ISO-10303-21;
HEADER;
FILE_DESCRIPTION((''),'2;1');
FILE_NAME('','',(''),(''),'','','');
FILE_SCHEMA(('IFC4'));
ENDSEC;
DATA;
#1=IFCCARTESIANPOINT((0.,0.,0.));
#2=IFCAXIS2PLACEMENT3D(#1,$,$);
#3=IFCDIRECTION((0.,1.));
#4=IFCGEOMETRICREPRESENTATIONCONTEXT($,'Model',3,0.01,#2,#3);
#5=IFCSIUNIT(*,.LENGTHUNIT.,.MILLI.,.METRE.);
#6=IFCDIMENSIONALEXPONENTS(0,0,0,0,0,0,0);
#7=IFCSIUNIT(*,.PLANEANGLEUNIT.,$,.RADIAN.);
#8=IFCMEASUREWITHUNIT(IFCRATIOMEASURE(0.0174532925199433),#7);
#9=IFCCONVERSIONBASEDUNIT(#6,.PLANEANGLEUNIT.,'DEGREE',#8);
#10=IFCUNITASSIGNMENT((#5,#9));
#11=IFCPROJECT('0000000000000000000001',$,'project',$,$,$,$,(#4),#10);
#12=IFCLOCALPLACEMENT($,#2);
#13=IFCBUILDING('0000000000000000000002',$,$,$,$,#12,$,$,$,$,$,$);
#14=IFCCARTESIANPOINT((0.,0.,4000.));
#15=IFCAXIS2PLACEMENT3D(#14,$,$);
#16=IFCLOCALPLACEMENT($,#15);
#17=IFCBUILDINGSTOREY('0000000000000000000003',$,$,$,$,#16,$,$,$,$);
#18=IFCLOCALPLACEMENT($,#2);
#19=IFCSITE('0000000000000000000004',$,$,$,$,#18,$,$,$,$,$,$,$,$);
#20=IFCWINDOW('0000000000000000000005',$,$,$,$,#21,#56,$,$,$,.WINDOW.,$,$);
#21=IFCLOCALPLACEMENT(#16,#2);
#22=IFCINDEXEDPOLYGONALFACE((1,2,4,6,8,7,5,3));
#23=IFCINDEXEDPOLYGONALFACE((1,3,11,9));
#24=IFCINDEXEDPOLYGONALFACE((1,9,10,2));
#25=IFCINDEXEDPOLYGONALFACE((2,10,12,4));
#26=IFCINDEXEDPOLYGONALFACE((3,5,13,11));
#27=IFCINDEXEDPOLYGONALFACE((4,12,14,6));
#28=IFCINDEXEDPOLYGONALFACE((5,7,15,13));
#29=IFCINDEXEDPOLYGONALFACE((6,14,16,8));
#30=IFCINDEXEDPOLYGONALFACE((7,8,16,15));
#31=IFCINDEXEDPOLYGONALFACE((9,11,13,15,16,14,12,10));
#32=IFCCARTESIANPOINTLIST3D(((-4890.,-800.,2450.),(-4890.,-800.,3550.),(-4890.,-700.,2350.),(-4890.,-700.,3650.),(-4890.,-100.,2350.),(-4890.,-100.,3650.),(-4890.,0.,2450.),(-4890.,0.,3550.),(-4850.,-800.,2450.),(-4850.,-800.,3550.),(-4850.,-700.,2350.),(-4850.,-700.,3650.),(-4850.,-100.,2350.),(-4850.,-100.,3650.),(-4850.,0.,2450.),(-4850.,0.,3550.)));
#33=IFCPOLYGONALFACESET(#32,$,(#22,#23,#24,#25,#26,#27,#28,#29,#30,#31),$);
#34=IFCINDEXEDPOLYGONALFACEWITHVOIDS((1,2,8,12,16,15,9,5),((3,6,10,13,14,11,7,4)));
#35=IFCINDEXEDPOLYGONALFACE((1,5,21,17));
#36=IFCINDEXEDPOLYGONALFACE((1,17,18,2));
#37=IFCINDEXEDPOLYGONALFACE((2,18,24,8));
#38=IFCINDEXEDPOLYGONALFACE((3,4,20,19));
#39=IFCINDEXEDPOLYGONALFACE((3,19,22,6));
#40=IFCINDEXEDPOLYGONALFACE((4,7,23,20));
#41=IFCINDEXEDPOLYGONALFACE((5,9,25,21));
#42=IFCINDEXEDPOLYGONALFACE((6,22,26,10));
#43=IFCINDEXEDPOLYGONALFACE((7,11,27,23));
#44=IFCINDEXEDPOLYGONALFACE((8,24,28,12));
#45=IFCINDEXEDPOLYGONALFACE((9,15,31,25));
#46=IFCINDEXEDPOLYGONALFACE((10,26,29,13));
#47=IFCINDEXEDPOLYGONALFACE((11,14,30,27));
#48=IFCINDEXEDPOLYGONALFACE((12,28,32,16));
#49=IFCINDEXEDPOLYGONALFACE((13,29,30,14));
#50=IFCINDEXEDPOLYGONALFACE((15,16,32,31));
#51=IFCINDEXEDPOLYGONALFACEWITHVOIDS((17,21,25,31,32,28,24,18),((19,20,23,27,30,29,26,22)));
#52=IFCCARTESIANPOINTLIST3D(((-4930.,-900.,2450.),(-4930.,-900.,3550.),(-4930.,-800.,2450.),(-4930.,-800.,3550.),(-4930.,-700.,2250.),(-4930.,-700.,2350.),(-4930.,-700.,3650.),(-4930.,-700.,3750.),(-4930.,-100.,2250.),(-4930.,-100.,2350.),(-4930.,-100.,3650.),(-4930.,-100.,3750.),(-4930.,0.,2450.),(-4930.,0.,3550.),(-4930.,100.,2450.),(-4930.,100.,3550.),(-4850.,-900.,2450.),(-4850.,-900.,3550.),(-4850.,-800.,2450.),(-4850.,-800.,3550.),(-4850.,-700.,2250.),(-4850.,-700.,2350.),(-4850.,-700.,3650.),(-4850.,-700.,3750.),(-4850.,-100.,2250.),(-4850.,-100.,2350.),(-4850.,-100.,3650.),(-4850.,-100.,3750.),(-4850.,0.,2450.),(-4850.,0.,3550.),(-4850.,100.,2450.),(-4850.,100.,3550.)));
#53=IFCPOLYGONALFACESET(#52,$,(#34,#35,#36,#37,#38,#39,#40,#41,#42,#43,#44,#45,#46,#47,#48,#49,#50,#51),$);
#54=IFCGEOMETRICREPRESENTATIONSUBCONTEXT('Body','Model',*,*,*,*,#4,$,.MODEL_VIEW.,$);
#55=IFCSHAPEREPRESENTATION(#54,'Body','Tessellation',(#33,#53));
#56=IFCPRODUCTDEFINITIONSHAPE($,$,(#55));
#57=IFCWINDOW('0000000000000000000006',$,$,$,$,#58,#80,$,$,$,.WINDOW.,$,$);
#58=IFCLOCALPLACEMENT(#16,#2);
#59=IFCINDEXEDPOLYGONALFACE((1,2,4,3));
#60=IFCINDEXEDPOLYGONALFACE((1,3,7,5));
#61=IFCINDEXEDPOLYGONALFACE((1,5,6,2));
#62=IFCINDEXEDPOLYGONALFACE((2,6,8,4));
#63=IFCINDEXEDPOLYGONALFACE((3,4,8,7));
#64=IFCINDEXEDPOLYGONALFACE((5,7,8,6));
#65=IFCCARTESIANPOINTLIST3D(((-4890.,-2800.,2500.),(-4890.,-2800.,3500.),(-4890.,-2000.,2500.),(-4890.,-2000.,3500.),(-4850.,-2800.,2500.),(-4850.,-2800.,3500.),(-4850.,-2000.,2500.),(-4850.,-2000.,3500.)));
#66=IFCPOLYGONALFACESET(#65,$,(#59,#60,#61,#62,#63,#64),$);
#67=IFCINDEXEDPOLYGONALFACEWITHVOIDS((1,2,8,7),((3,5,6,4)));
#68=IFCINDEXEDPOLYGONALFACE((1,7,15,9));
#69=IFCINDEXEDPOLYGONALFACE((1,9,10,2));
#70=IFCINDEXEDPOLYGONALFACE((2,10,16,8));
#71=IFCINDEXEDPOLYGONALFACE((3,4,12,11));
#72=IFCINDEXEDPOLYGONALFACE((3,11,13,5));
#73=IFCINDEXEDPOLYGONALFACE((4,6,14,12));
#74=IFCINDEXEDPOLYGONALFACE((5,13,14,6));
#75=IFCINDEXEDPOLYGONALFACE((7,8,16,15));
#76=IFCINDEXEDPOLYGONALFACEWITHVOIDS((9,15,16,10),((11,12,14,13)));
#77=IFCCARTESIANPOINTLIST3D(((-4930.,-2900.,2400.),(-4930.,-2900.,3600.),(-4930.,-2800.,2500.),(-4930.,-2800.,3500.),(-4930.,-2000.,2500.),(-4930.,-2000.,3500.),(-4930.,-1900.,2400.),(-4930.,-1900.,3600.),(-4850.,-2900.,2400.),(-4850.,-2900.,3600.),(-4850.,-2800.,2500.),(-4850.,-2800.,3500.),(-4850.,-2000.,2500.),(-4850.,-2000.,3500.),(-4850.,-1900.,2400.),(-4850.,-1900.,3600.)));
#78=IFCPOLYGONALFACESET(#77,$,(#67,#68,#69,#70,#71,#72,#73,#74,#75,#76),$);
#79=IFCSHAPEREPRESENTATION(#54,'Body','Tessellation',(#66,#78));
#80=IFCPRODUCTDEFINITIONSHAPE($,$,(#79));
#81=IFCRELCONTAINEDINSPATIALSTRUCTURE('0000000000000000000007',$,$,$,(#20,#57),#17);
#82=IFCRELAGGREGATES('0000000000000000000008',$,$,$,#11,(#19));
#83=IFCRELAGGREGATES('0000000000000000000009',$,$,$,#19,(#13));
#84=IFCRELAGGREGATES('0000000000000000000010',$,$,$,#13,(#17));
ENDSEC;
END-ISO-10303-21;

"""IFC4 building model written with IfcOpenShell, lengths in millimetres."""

from ifc_helpers import new_model, entity, si_unit, converted_unit, direction, frame, origin, place, context, subcontext, project, spatial, element, save


model = new_model("IFC4")

# Units and contexts
model_context = context("Model", 3, precision=0.01, world=origin(), true_north=direction((0.0, 1.0)))
body_context = subcontext(model_context, "Body", "Model", "MODEL_VIEW")
ifc_project = project(units=[si_unit("LENGTHUNIT", "METRE", prefix="MILLI"), converted_unit("PLANEANGLEUNIT", "DEGREE", entity("IfcRatioMeasure", 0.0174532925199433), si_unit("PLANEANGLEUNIT", "RADIAN"), dimensions=[0, 0, 0, 0, 0, 0, 0])], contexts=[model_context])

# Site, building, storey
site_placement = place(None, origin())
site = spatial("IfcSite", under=ifc_project, at=site_placement)
building_placement = place(None, origin())
building = spatial("IfcBuilding", under=site, at=building_placement)
storey_placement = place(None, frame((0.0, 0.0, 4000.0)))
storey = spatial("IfcBuildingStorey", under=building, at=storey_placement)

# Shared definitions
cartesian_point_1 = entity("IfcCartesianPoint", [-400.0, -550.0])
shared_polyline_1 = entity("IfcPolyline", [cartesian_point_1, entity("IfcCartesianPoint", [-400.0, 550.0]), entity("IfcCartesianPoint", [-300.0, 650.0]), entity("IfcCartesianPoint", [300.0, 650.0]), entity("IfcCartesianPoint", [400.0, 550.0]), entity("IfcCartesianPoint", [400.0, -550.0]), entity("IfcCartesianPoint", [300.0, -650.0]), entity("IfcCartesianPoint", [-300.0, -650.0]), cartesian_point_1])
cartesian_point_2 = entity("IfcCartesianPoint", [-400.0, -500.0])
shared_polyline_2 = entity("IfcPolyline", [cartesian_point_2, entity("IfcCartesianPoint", [-400.0, 500.0]), entity("IfcCartesianPoint", [-400.0, 500.0]), entity("IfcCartesianPoint", [400.0, 500.0]), entity("IfcCartesianPoint", [400.0, 500.0]), entity("IfcCartesianPoint", [400.0, -500.0]), entity("IfcCartesianPoint", [400.0, -500.0]), entity("IfcCartesianPoint", [-400.0, -500.0]), cartesian_point_2])

# Shared definitions
wall_1_placement = place(storey_placement, frame((-4900.0, 100.0, 0.0), z_axis=(0.0, 0.0, 1.0), x_axis=(0.0, -1.0, 0.0)))
window_1_placement = place(wall_1_placement, frame((500.0, 50.0, 3000.0)))
window_2_placement = place(wall_1_placement, frame((2500.0, 50.0, 3000.0)))

# Windows
cartesian_point_3 = entity("IfcCartesianPoint", [-500.0, -550.0])
element("IfcWindow", 1, at=window_1_placement, inside=storey, PredefinedType="WINDOW", context=body_context, shape_type="SweptSolid", body=[
    entity("IfcExtrudedAreaSolid", entity("IfcArbitraryClosedProfileDef", "AREA", None, shared_polyline_1), entity("IfcAxis2Placement3D", entity("IfcCartesianPoint", [0.0, 0.0, 0.0]), entity("IfcDirection", [0.0, -1.0, 0.0]), entity("IfcDirection", [1.0, 0.0, 0.0])), entity("IfcDirection", [0.0, 0.0, 1.0]), 40.0),
    entity("IfcExtrudedAreaSolid", entity("IfcArbitraryProfileDefWithVoids", "AREA", None, entity("IfcPolyline", [cartesian_point_3, entity("IfcCartesianPoint", [-500.0, 550.0]), entity("IfcCartesianPoint", [-300.0, 750.0]), entity("IfcCartesianPoint", [300.0, 750.0]), entity("IfcCartesianPoint", [500.0, 550.0]), entity("IfcCartesianPoint", [500.0, -550.0]), entity("IfcCartesianPoint", [300.0, -750.0]), entity("IfcCartesianPoint", [-300.0, -750.0]), cartesian_point_3]), [shared_polyline_1]), entity("IfcAxis2Placement3D", entity("IfcCartesianPoint", [0.0, 0.0, 0.0]), entity("IfcDirection", [0.0, -1.0, 0.0]), entity("IfcDirection", [1.0, 0.0, 0.0])), entity("IfcDirection", [0.0, 0.0, 1.0]), 80.0),
])
cartesian_point_4 = entity("IfcCartesianPoint", [-500.0, -600.0])
element("IfcWindow", 2, at=window_2_placement, inside=storey, PredefinedType="WINDOW", context=body_context, shape_type="SweptSolid", body=[
    entity("IfcExtrudedAreaSolid", entity("IfcArbitraryClosedProfileDef", "AREA", None, shared_polyline_2), entity("IfcAxis2Placement3D", entity("IfcCartesianPoint", [0.0, 0.0, 0.0]), entity("IfcDirection", [0.0, -1.0, 0.0]), entity("IfcDirection", [1.0, 0.0, 0.0])), entity("IfcDirection", [0.0, 0.0, 1.0]), 40.0),
    entity("IfcExtrudedAreaSolid", entity("IfcArbitraryProfileDefWithVoids", "AREA", None, entity("IfcPolyline", [cartesian_point_4, entity("IfcCartesianPoint", [-500.0, 600.0]), entity("IfcCartesianPoint", [-500.0, 600.0]), entity("IfcCartesianPoint", [500.0, 600.0]), entity("IfcCartesianPoint", [500.0, 600.0]), entity("IfcCartesianPoint", [500.0, -600.0]), entity("IfcCartesianPoint", [500.0, -600.0]), entity("IfcCartesianPoint", [-500.0, -600.0]), cartesian_point_4]), [shared_polyline_2]), entity("IfcAxis2Placement3D", entity("IfcCartesianPoint", [0.0, 0.0, 0.0]), entity("IfcDirection", [0.0, -1.0, 0.0]), entity("IfcDirection", [1.0, 0.0, 0.0])), entity("IfcDirection", [0.0, 0.0, 1.0]), 80.0),
])

save(model, "model.ifc")
